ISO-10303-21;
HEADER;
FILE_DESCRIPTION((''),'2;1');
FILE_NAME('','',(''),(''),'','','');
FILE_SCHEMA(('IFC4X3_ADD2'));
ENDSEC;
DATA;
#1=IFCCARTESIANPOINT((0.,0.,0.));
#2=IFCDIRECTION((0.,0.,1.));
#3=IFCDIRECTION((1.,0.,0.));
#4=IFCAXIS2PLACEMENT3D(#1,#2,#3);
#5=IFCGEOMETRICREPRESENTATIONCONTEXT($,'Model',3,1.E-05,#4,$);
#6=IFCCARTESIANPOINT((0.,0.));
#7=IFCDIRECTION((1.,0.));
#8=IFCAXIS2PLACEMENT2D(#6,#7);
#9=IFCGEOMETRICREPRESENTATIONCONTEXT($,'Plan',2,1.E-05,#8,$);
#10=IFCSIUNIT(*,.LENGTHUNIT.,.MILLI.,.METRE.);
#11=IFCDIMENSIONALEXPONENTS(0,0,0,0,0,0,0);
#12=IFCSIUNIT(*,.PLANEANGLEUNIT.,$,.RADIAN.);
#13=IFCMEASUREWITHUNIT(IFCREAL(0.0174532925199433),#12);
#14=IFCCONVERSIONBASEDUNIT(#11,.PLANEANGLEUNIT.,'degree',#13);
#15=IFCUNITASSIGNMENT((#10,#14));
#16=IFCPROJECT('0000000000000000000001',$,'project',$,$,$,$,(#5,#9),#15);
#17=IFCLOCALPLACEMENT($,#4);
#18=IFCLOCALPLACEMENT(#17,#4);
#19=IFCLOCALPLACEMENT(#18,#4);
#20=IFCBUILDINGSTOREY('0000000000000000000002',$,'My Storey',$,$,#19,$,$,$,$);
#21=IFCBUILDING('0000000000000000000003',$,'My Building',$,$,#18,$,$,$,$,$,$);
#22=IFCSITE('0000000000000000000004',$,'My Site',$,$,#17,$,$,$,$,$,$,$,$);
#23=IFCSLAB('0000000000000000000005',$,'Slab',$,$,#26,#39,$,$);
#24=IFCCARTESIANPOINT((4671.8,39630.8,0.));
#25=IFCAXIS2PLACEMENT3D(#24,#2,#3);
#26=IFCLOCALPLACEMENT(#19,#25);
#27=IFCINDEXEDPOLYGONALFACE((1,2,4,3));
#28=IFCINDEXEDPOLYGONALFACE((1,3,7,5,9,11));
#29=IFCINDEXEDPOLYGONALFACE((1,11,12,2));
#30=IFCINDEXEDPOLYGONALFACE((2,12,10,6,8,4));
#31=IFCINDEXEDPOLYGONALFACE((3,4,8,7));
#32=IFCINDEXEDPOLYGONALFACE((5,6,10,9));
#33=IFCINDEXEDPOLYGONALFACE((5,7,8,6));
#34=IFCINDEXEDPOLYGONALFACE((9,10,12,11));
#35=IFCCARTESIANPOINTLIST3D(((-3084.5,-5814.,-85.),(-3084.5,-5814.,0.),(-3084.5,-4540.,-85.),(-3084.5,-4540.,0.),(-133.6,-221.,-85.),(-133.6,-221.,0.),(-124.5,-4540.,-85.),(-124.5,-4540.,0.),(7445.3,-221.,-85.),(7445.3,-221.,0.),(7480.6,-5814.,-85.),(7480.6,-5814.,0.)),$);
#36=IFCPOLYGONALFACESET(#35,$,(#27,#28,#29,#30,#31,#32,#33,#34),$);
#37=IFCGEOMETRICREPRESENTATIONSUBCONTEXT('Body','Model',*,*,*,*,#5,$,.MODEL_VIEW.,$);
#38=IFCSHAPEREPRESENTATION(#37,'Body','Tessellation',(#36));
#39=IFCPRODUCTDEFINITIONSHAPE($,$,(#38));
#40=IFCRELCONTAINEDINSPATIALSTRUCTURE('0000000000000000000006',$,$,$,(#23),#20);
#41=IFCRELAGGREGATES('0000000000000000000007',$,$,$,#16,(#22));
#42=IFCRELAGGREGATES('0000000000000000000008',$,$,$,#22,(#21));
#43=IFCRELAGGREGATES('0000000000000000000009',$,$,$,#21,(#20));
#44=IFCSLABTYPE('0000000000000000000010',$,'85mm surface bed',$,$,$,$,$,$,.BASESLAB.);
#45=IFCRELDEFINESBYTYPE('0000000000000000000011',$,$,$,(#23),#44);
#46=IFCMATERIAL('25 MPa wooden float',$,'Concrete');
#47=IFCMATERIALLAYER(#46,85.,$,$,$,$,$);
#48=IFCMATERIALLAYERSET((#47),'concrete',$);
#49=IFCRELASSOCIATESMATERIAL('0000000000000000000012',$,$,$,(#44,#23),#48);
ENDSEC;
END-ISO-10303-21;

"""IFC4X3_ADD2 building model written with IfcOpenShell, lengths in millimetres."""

from ifc_helpers import new_model, entity, si_unit, converted_unit, frame, origin_with_axes, origin_2d_with_axis, place, context, subcontext, project, spatial, indexed_curve, outline, extrude, material, layer, layer_set, layer_usage, type_object, element, save


model = new_model("IFC4X3_ADD2")

# Units and contexts
model_context = context("Model", 3, precision=1e-05, world=origin_with_axes())
plan_context = context("Plan", 2, precision=1e-05, world=origin_2d_with_axis())
body_context_1 = subcontext(model_context, "Body", "Model", "MODEL_VIEW")
ifc_project = project(units=[si_unit("LENGTHUNIT", "METRE", prefix="MILLI"), converted_unit("PLANEANGLEUNIT", "degree", entity("IfcReal", 0.0174532925199433), si_unit("PLANEANGLEUNIT", "RADIAN"), dimensions=[0, 0, 0, 0, 0, 0, 0])], contexts=[model_context, plan_context])

# Site, building, storey
site_placement = place(None, origin_with_axes())
site = spatial("IfcSite", under=ifc_project, at=site_placement, Name="My Site")
building_placement = place(site_placement, origin_with_axes())
building = spatial("IfcBuilding", under=site, at=building_placement, Name="My Building")
storey_placement = place(building_placement, origin_with_axes())
storey = spatial("IfcBuildingStorey", under=building, at=storey_placement, Name="My Storey")

# Slab
ifc_material_1 = material(Name="25 MPa wooden float", Category="Concrete")
ifc_layer_1 = layer(ifc_material_1, 85.0)
ifc_layer_set_1 = layer_set([ifc_layer_1], Name="concrete")
ifc_layer_usage_1 = layer_usage(ifc_layer_set_1, "AXIS3", "POSITIVE", -85.0)
slab_type = type_object("IfcSlabType", Name="85mm surface bed", PredefinedType="BASESLAB", material=ifc_layer_set_1)
slab_placement = place(storey_placement, frame((4671.8, 39630.8, 0.0), z_axis=(0.0, 0.0, 1.0), x_axis=(1.0, 0.0, 0.0)))
element("IfcSlab", 1, at=slab_placement, inside=storey, type_object=slab_type, material=ifc_layer_usage_1, Name="Slab", context=body_context_1, shape_type="SweptSolid", body=[
    extrude(outline(indexed_curve([(7445.3, -221.0), (7480.6, -5814.0), (-3084.5, -5814.0), (-3084.5, -4540.0), (-124.5, -4540.0), (-133.6, -221.0), (7445.3, -221.0)])), frame((0.0, 0.0, -85.0), z_axis=(0.0, 0.0, 1.0), x_axis=(1.0, 0.0, 0.0)), (0.0, 0.0, 1.0), 85.0),
])

save(model, "model.ifc")
